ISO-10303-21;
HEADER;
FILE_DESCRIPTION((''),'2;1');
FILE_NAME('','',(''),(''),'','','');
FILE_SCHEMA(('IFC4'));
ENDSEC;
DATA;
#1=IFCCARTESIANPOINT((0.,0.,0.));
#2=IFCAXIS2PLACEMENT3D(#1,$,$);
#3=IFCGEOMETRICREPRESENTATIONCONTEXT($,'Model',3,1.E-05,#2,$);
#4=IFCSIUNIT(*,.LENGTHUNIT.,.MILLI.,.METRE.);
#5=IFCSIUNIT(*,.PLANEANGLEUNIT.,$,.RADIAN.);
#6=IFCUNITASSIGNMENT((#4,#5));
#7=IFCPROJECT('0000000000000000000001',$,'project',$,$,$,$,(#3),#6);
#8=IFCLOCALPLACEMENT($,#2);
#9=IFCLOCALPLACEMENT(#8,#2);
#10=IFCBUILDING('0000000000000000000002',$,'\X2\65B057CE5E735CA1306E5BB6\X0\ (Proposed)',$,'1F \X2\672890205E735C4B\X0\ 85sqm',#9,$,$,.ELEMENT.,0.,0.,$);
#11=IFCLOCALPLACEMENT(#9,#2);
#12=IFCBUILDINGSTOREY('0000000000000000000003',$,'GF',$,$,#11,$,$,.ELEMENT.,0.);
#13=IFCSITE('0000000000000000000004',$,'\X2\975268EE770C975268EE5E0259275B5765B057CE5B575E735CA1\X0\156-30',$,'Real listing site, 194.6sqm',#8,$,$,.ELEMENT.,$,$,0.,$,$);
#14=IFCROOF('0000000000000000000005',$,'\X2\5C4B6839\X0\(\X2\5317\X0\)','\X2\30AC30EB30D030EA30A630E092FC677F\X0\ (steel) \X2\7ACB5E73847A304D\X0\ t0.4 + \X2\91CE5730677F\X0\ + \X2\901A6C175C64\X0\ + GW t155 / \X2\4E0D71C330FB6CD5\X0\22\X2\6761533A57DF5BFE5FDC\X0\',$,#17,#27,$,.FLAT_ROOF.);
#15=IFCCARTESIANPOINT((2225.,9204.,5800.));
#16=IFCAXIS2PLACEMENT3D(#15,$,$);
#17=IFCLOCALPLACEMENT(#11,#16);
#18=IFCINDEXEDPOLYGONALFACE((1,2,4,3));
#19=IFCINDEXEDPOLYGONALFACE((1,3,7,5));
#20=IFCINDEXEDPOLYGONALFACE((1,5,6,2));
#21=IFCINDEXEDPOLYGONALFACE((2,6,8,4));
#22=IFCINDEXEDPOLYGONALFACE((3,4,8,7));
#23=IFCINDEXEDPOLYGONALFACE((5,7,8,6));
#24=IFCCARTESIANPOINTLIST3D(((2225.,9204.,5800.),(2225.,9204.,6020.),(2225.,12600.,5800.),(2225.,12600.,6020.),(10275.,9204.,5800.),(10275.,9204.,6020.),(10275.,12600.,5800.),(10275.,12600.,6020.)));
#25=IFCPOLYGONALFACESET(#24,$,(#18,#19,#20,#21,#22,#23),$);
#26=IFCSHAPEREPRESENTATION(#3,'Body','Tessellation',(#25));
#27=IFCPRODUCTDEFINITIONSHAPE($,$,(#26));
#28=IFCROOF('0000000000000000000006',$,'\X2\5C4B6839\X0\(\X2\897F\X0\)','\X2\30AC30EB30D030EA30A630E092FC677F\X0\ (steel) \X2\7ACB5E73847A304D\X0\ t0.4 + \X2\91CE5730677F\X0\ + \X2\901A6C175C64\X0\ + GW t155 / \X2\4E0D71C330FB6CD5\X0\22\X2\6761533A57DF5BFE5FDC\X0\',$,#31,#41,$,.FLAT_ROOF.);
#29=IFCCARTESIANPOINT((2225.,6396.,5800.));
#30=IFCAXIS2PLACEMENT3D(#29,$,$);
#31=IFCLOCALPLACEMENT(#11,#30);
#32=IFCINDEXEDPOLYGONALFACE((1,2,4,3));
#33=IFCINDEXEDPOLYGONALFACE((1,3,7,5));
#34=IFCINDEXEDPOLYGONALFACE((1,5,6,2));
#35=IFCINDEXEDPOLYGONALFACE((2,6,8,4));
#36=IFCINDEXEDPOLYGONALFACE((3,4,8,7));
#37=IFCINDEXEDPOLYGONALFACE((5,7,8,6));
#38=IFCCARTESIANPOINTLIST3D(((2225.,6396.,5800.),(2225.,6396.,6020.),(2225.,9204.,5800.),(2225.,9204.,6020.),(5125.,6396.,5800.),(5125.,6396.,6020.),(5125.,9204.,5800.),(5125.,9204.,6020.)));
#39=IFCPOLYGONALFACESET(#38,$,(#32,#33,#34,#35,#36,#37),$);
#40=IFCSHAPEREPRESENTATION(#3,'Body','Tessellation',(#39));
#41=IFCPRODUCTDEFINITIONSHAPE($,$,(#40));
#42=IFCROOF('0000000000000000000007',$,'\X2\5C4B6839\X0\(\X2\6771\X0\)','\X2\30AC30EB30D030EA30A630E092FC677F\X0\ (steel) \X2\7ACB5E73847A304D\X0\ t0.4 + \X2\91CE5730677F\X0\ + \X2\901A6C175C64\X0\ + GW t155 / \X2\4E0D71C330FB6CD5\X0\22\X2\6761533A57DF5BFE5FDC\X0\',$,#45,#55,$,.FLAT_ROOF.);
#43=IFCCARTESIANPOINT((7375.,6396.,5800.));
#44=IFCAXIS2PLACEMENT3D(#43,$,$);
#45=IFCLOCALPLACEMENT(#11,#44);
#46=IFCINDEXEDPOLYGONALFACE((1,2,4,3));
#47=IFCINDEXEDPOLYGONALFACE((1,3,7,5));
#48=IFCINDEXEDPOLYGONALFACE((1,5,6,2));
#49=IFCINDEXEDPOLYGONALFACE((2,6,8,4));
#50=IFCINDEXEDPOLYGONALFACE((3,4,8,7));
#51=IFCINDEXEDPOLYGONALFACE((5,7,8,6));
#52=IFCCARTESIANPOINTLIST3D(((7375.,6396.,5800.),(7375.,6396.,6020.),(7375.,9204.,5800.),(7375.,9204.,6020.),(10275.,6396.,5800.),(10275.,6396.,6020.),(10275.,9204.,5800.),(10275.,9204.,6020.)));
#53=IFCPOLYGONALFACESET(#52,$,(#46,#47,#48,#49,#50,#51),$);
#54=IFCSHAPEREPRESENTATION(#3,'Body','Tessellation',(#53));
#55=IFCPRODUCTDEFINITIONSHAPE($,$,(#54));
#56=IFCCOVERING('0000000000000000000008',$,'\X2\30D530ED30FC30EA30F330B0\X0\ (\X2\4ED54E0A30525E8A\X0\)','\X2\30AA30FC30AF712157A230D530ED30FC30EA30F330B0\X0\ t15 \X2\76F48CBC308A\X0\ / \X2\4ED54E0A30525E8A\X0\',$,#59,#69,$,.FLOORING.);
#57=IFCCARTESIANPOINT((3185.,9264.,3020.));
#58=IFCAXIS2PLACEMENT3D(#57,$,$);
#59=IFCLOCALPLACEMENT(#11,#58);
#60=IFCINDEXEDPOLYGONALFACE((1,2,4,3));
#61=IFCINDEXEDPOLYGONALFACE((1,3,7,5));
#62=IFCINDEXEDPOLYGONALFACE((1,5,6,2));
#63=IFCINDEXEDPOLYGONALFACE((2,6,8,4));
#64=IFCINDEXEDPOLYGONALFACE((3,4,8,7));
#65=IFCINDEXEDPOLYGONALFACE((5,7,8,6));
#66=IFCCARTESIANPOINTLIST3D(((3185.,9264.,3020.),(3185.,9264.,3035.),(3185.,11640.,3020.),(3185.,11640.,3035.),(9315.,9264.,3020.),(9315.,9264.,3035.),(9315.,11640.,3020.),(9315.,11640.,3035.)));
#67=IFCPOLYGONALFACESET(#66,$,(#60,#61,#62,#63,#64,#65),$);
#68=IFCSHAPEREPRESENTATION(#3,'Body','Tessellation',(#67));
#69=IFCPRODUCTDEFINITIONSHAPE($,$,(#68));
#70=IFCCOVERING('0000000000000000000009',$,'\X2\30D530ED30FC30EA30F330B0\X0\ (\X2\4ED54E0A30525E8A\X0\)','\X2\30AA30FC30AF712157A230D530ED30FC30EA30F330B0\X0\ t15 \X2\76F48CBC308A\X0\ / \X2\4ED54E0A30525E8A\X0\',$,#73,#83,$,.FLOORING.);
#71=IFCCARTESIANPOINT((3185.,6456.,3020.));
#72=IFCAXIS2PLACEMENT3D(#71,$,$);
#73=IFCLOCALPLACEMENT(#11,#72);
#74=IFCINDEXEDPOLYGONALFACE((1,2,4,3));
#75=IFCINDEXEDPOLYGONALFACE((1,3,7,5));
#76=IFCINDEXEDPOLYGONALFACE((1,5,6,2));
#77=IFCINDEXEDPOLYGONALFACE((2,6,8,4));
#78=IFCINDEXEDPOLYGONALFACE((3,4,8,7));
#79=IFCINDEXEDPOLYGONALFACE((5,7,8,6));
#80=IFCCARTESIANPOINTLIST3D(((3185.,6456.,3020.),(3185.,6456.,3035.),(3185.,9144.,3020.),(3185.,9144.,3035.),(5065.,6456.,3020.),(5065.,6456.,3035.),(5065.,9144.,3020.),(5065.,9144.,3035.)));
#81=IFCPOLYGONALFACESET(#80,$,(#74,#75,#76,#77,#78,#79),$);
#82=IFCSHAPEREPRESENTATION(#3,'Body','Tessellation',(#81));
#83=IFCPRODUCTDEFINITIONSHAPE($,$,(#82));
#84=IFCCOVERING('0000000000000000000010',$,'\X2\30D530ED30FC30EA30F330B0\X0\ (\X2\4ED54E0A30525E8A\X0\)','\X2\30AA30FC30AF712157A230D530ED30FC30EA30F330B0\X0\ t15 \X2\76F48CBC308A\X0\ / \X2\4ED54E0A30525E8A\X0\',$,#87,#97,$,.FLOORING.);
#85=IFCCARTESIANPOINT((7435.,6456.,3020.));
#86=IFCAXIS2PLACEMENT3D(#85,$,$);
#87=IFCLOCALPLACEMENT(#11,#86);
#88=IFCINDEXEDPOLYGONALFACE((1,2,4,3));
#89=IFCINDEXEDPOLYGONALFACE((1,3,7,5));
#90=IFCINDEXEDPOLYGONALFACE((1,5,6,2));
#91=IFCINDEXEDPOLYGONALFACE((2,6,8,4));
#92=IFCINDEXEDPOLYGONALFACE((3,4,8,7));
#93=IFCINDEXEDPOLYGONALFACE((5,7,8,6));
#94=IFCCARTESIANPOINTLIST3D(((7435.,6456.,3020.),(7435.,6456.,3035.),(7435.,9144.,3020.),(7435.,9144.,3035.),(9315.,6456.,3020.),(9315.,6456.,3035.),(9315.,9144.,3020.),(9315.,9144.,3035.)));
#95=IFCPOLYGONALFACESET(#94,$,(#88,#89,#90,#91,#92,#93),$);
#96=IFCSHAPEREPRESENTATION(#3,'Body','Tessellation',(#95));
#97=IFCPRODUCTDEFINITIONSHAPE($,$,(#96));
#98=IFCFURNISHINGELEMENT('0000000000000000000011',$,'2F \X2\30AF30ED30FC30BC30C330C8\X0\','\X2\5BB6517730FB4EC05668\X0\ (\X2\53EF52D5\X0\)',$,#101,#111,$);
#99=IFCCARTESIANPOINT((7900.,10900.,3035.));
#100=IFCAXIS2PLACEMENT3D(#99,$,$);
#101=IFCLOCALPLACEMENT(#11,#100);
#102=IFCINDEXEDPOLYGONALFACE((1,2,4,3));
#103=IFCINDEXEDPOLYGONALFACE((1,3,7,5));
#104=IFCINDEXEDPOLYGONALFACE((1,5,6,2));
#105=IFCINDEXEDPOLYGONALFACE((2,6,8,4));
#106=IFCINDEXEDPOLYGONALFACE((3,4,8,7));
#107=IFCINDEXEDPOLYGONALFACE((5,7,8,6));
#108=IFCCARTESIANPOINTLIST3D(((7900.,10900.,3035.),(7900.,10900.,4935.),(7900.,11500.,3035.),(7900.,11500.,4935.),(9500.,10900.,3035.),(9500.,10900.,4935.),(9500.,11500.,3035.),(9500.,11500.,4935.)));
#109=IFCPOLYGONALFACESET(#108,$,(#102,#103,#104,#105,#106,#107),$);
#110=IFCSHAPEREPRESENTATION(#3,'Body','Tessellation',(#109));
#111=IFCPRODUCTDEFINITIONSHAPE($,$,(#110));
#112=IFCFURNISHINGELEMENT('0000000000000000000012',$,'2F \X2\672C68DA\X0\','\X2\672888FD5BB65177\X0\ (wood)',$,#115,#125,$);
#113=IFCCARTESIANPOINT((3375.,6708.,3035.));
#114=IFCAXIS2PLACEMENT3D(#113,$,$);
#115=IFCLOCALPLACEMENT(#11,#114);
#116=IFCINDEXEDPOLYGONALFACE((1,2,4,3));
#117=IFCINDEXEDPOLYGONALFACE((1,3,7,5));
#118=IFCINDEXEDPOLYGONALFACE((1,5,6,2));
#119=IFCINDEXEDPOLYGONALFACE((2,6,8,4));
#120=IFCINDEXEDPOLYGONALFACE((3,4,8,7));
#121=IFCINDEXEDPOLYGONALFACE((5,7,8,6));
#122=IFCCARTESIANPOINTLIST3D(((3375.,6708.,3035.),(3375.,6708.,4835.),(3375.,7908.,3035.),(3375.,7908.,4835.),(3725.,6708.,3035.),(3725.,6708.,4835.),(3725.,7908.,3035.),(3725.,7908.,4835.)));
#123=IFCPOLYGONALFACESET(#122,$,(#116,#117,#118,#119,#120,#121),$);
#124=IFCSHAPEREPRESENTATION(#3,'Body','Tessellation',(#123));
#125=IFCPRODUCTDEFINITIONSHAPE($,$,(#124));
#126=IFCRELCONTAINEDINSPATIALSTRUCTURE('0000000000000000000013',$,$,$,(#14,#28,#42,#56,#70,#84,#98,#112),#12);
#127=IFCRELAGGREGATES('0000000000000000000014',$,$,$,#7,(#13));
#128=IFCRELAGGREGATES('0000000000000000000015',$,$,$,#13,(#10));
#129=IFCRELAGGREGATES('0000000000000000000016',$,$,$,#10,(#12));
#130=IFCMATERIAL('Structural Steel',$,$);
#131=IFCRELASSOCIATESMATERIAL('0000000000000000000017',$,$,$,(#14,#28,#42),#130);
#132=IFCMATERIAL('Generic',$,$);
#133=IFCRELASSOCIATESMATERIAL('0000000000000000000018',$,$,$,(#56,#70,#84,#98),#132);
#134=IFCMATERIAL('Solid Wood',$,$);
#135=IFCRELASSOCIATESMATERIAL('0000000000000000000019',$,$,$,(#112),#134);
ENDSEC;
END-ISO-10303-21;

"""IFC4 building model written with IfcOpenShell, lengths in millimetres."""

from ifc_helpers import new_model, si_unit, frame, frame_2d, origin, place, context, project, spatial, rectangle, extrude, material, element, save


model = new_model("IFC4")

# Units and contexts
model_context = context("Model", 3, precision=1e-05, world=origin())
ifc_project = project(units=[si_unit("LENGTHUNIT", "METRE", prefix="MILLI"), si_unit("PLANEANGLEUNIT", "RADIAN")], contexts=[model_context])

# Site, building, storey
site_placement = place(None, origin())
site = spatial("IfcSite", under=ifc_project, at=site_placement, Name="青森県青森市大字新城字平岡156-30", ObjectType="Real listing site, 194.6sqm", CompositionType="ELEMENT", RefElevation=0.0)
building_placement = place(site_placement, origin())
building = spatial("IfcBuilding", under=site, at=building_placement, Name="新城平岡の家 (Proposed)", ObjectType="1F 木造平屋 85sqm", CompositionType="ELEMENT", ElevationOfRefHeight=0.0, ElevationOfTerrain=0.0)
storey_placement = place(building_placement, origin())
storey = spatial("IfcBuildingStorey", under=building, at=storey_placement, Name="GF", CompositionType="ELEMENT", Elevation=0.0)

# Shared definitions
ifc_material_1 = material(Name="Solid Wood")

# Shared definitions
ifc_material_2 = material(Name="Generic")

# Roofs
ifc_material_3 = material(Name="Structural Steel")
for number, where, name in (
    (1, (2225.0, 9204.0, 5800.0), "屋根(北)"),
):
    element("IfcRoof", number, at=place(storey_placement, frame(where)), inside=storey, material=ifc_material_3, Name=name, Description="ガルバリウム鋼板 (steel) 立平葺き t0.4 + 野地板 + 通気層 + GW t155 / 不燃・法22条区域対応", PredefinedType="FLAT_ROOF", context=model_context, shape_type="SweptSolid", body=[
        extrude(rectangle(XDim=8050.0, YDim=3396.0, at=frame_2d((4025.0, 1698.0))), frame((2225.0, 9204.0, 5800.0)), (0.0, 0.0, 1.0), 220.0),
    ])
roof_1_placement = place(storey_placement, frame((2225.0, 6396.0, 5800.0)))
element("IfcRoof", 2, at=roof_1_placement, inside=storey, material=ifc_material_3, Name="屋根(西)", Description="ガルバリウム鋼板 (steel) 立平葺き t0.4 + 野地板 + 通気層 + GW t155 / 不燃・法22条区域対応", PredefinedType="FLAT_ROOF", context=model_context, shape_type="SweptSolid", body=[
    extrude(rectangle(XDim=2900.0, YDim=2808.0, at=frame_2d((1450.0, 1404.0))), frame((2225.0, 6396.0, 5800.0)), (0.0, 0.0, 1.0), 220.0),
])
roof_2_placement = place(storey_placement, frame((7375.0, 6396.0, 5800.0)))
element("IfcRoof", 3, at=roof_2_placement, inside=storey, material=ifc_material_3, Name="屋根(東)", Description="ガルバリウム鋼板 (steel) 立平葺き t0.4 + 野地板 + 通気層 + GW t155 / 不燃・法22条区域対応", PredefinedType="FLAT_ROOF", context=model_context, shape_type="SweptSolid", body=[
    extrude(rectangle(XDim=2900.0, YDim=2808.0, at=frame_2d((1450.0, 1404.0))), frame((7375.0, 6396.0, 5800.0)), (0.0, 0.0, 1.0), 220.0),
])

# Coverings
covering_1_placement = place(storey_placement, frame((3185.0, 9264.0, 3020.0)))
element("IfcCovering", 4, at=covering_1_placement, inside=storey, material=ifc_material_2, Name="フローリング (仕上げ床)", Description="オーク無垢フローリング t15 直貼り / 仕上げ床", PredefinedType="FLOORING", context=model_context, shape_type="SweptSolid", body=[
    extrude(rectangle(XDim=6130.0, YDim=2376.0, at=frame_2d((3065.0, 1188.0))), frame((3185.0, 9264.0, 3020.0)), (0.0, 0.0, 1.0), 15.0),
])
covering_2_placement = place(storey_placement, frame((3185.0, 6456.0, 3020.0)))
element("IfcCovering", 5, at=covering_2_placement, inside=storey, material=ifc_material_2, Name="フローリング (仕上げ床)", Description="オーク無垢フローリング t15 直貼り / 仕上げ床", PredefinedType="FLOORING", context=model_context, shape_type="SweptSolid", body=[
    extrude(rectangle(XDim=1880.0, YDim=2688.0, at=frame_2d((940.0, 1344.0))), frame((3185.0, 6456.0, 3020.0)), (0.0, 0.0, 1.0), 15.0),
])
covering_3_placement = place(storey_placement, frame((7435.0, 6456.0, 3020.0)))
element("IfcCovering", 6, at=covering_3_placement, inside=storey, material=ifc_material_2, Name="フローリング (仕上げ床)", Description="オーク無垢フローリング t15 直貼り / 仕上げ床", PredefinedType="FLOORING", context=model_context, shape_type="SweptSolid", body=[
    extrude(rectangle(XDim=1880.0, YDim=2688.0, at=frame_2d((940.0, 1344.0))), frame((7435.0, 6456.0, 3020.0)), (0.0, 0.0, 1.0), 15.0),
])

# Furnishing elements
furnishing_1_placement = place(storey_placement, frame((7900.0, 10900.0, 3035.0)))
element("IfcFurnishingElement", 7, at=furnishing_1_placement, inside=storey, material=ifc_material_2, Name="2F クローゼット", Description="家具・什器 (可動)", context=model_context, shape_type="SweptSolid", body=[
    extrude(rectangle(XDim=1600.0, YDim=600.0, at=frame_2d((800.0, 300.0))), frame((7900.0, 10900.0, 3035.0)), (0.0, 0.0, 1.0), 1900.0),
])
furnishing_2_placement = place(storey_placement, frame((3375.0, 6708.0, 3035.0)))
element("IfcFurnishingElement", 8, at=furnishing_2_placement, inside=storey, material=ifc_material_1, Name="2F 本棚", Description="木製家具 (wood)", context=model_context, shape_type="SweptSolid", body=[
    extrude(rectangle(XDim=350.0, YDim=1200.0, at=frame_2d((175.0, 600.0))), frame((3375.0, 6708.0, 3035.0)), (0.0, 0.0, 1.0), 1800.0),
])

save(model, "model.ifc")
